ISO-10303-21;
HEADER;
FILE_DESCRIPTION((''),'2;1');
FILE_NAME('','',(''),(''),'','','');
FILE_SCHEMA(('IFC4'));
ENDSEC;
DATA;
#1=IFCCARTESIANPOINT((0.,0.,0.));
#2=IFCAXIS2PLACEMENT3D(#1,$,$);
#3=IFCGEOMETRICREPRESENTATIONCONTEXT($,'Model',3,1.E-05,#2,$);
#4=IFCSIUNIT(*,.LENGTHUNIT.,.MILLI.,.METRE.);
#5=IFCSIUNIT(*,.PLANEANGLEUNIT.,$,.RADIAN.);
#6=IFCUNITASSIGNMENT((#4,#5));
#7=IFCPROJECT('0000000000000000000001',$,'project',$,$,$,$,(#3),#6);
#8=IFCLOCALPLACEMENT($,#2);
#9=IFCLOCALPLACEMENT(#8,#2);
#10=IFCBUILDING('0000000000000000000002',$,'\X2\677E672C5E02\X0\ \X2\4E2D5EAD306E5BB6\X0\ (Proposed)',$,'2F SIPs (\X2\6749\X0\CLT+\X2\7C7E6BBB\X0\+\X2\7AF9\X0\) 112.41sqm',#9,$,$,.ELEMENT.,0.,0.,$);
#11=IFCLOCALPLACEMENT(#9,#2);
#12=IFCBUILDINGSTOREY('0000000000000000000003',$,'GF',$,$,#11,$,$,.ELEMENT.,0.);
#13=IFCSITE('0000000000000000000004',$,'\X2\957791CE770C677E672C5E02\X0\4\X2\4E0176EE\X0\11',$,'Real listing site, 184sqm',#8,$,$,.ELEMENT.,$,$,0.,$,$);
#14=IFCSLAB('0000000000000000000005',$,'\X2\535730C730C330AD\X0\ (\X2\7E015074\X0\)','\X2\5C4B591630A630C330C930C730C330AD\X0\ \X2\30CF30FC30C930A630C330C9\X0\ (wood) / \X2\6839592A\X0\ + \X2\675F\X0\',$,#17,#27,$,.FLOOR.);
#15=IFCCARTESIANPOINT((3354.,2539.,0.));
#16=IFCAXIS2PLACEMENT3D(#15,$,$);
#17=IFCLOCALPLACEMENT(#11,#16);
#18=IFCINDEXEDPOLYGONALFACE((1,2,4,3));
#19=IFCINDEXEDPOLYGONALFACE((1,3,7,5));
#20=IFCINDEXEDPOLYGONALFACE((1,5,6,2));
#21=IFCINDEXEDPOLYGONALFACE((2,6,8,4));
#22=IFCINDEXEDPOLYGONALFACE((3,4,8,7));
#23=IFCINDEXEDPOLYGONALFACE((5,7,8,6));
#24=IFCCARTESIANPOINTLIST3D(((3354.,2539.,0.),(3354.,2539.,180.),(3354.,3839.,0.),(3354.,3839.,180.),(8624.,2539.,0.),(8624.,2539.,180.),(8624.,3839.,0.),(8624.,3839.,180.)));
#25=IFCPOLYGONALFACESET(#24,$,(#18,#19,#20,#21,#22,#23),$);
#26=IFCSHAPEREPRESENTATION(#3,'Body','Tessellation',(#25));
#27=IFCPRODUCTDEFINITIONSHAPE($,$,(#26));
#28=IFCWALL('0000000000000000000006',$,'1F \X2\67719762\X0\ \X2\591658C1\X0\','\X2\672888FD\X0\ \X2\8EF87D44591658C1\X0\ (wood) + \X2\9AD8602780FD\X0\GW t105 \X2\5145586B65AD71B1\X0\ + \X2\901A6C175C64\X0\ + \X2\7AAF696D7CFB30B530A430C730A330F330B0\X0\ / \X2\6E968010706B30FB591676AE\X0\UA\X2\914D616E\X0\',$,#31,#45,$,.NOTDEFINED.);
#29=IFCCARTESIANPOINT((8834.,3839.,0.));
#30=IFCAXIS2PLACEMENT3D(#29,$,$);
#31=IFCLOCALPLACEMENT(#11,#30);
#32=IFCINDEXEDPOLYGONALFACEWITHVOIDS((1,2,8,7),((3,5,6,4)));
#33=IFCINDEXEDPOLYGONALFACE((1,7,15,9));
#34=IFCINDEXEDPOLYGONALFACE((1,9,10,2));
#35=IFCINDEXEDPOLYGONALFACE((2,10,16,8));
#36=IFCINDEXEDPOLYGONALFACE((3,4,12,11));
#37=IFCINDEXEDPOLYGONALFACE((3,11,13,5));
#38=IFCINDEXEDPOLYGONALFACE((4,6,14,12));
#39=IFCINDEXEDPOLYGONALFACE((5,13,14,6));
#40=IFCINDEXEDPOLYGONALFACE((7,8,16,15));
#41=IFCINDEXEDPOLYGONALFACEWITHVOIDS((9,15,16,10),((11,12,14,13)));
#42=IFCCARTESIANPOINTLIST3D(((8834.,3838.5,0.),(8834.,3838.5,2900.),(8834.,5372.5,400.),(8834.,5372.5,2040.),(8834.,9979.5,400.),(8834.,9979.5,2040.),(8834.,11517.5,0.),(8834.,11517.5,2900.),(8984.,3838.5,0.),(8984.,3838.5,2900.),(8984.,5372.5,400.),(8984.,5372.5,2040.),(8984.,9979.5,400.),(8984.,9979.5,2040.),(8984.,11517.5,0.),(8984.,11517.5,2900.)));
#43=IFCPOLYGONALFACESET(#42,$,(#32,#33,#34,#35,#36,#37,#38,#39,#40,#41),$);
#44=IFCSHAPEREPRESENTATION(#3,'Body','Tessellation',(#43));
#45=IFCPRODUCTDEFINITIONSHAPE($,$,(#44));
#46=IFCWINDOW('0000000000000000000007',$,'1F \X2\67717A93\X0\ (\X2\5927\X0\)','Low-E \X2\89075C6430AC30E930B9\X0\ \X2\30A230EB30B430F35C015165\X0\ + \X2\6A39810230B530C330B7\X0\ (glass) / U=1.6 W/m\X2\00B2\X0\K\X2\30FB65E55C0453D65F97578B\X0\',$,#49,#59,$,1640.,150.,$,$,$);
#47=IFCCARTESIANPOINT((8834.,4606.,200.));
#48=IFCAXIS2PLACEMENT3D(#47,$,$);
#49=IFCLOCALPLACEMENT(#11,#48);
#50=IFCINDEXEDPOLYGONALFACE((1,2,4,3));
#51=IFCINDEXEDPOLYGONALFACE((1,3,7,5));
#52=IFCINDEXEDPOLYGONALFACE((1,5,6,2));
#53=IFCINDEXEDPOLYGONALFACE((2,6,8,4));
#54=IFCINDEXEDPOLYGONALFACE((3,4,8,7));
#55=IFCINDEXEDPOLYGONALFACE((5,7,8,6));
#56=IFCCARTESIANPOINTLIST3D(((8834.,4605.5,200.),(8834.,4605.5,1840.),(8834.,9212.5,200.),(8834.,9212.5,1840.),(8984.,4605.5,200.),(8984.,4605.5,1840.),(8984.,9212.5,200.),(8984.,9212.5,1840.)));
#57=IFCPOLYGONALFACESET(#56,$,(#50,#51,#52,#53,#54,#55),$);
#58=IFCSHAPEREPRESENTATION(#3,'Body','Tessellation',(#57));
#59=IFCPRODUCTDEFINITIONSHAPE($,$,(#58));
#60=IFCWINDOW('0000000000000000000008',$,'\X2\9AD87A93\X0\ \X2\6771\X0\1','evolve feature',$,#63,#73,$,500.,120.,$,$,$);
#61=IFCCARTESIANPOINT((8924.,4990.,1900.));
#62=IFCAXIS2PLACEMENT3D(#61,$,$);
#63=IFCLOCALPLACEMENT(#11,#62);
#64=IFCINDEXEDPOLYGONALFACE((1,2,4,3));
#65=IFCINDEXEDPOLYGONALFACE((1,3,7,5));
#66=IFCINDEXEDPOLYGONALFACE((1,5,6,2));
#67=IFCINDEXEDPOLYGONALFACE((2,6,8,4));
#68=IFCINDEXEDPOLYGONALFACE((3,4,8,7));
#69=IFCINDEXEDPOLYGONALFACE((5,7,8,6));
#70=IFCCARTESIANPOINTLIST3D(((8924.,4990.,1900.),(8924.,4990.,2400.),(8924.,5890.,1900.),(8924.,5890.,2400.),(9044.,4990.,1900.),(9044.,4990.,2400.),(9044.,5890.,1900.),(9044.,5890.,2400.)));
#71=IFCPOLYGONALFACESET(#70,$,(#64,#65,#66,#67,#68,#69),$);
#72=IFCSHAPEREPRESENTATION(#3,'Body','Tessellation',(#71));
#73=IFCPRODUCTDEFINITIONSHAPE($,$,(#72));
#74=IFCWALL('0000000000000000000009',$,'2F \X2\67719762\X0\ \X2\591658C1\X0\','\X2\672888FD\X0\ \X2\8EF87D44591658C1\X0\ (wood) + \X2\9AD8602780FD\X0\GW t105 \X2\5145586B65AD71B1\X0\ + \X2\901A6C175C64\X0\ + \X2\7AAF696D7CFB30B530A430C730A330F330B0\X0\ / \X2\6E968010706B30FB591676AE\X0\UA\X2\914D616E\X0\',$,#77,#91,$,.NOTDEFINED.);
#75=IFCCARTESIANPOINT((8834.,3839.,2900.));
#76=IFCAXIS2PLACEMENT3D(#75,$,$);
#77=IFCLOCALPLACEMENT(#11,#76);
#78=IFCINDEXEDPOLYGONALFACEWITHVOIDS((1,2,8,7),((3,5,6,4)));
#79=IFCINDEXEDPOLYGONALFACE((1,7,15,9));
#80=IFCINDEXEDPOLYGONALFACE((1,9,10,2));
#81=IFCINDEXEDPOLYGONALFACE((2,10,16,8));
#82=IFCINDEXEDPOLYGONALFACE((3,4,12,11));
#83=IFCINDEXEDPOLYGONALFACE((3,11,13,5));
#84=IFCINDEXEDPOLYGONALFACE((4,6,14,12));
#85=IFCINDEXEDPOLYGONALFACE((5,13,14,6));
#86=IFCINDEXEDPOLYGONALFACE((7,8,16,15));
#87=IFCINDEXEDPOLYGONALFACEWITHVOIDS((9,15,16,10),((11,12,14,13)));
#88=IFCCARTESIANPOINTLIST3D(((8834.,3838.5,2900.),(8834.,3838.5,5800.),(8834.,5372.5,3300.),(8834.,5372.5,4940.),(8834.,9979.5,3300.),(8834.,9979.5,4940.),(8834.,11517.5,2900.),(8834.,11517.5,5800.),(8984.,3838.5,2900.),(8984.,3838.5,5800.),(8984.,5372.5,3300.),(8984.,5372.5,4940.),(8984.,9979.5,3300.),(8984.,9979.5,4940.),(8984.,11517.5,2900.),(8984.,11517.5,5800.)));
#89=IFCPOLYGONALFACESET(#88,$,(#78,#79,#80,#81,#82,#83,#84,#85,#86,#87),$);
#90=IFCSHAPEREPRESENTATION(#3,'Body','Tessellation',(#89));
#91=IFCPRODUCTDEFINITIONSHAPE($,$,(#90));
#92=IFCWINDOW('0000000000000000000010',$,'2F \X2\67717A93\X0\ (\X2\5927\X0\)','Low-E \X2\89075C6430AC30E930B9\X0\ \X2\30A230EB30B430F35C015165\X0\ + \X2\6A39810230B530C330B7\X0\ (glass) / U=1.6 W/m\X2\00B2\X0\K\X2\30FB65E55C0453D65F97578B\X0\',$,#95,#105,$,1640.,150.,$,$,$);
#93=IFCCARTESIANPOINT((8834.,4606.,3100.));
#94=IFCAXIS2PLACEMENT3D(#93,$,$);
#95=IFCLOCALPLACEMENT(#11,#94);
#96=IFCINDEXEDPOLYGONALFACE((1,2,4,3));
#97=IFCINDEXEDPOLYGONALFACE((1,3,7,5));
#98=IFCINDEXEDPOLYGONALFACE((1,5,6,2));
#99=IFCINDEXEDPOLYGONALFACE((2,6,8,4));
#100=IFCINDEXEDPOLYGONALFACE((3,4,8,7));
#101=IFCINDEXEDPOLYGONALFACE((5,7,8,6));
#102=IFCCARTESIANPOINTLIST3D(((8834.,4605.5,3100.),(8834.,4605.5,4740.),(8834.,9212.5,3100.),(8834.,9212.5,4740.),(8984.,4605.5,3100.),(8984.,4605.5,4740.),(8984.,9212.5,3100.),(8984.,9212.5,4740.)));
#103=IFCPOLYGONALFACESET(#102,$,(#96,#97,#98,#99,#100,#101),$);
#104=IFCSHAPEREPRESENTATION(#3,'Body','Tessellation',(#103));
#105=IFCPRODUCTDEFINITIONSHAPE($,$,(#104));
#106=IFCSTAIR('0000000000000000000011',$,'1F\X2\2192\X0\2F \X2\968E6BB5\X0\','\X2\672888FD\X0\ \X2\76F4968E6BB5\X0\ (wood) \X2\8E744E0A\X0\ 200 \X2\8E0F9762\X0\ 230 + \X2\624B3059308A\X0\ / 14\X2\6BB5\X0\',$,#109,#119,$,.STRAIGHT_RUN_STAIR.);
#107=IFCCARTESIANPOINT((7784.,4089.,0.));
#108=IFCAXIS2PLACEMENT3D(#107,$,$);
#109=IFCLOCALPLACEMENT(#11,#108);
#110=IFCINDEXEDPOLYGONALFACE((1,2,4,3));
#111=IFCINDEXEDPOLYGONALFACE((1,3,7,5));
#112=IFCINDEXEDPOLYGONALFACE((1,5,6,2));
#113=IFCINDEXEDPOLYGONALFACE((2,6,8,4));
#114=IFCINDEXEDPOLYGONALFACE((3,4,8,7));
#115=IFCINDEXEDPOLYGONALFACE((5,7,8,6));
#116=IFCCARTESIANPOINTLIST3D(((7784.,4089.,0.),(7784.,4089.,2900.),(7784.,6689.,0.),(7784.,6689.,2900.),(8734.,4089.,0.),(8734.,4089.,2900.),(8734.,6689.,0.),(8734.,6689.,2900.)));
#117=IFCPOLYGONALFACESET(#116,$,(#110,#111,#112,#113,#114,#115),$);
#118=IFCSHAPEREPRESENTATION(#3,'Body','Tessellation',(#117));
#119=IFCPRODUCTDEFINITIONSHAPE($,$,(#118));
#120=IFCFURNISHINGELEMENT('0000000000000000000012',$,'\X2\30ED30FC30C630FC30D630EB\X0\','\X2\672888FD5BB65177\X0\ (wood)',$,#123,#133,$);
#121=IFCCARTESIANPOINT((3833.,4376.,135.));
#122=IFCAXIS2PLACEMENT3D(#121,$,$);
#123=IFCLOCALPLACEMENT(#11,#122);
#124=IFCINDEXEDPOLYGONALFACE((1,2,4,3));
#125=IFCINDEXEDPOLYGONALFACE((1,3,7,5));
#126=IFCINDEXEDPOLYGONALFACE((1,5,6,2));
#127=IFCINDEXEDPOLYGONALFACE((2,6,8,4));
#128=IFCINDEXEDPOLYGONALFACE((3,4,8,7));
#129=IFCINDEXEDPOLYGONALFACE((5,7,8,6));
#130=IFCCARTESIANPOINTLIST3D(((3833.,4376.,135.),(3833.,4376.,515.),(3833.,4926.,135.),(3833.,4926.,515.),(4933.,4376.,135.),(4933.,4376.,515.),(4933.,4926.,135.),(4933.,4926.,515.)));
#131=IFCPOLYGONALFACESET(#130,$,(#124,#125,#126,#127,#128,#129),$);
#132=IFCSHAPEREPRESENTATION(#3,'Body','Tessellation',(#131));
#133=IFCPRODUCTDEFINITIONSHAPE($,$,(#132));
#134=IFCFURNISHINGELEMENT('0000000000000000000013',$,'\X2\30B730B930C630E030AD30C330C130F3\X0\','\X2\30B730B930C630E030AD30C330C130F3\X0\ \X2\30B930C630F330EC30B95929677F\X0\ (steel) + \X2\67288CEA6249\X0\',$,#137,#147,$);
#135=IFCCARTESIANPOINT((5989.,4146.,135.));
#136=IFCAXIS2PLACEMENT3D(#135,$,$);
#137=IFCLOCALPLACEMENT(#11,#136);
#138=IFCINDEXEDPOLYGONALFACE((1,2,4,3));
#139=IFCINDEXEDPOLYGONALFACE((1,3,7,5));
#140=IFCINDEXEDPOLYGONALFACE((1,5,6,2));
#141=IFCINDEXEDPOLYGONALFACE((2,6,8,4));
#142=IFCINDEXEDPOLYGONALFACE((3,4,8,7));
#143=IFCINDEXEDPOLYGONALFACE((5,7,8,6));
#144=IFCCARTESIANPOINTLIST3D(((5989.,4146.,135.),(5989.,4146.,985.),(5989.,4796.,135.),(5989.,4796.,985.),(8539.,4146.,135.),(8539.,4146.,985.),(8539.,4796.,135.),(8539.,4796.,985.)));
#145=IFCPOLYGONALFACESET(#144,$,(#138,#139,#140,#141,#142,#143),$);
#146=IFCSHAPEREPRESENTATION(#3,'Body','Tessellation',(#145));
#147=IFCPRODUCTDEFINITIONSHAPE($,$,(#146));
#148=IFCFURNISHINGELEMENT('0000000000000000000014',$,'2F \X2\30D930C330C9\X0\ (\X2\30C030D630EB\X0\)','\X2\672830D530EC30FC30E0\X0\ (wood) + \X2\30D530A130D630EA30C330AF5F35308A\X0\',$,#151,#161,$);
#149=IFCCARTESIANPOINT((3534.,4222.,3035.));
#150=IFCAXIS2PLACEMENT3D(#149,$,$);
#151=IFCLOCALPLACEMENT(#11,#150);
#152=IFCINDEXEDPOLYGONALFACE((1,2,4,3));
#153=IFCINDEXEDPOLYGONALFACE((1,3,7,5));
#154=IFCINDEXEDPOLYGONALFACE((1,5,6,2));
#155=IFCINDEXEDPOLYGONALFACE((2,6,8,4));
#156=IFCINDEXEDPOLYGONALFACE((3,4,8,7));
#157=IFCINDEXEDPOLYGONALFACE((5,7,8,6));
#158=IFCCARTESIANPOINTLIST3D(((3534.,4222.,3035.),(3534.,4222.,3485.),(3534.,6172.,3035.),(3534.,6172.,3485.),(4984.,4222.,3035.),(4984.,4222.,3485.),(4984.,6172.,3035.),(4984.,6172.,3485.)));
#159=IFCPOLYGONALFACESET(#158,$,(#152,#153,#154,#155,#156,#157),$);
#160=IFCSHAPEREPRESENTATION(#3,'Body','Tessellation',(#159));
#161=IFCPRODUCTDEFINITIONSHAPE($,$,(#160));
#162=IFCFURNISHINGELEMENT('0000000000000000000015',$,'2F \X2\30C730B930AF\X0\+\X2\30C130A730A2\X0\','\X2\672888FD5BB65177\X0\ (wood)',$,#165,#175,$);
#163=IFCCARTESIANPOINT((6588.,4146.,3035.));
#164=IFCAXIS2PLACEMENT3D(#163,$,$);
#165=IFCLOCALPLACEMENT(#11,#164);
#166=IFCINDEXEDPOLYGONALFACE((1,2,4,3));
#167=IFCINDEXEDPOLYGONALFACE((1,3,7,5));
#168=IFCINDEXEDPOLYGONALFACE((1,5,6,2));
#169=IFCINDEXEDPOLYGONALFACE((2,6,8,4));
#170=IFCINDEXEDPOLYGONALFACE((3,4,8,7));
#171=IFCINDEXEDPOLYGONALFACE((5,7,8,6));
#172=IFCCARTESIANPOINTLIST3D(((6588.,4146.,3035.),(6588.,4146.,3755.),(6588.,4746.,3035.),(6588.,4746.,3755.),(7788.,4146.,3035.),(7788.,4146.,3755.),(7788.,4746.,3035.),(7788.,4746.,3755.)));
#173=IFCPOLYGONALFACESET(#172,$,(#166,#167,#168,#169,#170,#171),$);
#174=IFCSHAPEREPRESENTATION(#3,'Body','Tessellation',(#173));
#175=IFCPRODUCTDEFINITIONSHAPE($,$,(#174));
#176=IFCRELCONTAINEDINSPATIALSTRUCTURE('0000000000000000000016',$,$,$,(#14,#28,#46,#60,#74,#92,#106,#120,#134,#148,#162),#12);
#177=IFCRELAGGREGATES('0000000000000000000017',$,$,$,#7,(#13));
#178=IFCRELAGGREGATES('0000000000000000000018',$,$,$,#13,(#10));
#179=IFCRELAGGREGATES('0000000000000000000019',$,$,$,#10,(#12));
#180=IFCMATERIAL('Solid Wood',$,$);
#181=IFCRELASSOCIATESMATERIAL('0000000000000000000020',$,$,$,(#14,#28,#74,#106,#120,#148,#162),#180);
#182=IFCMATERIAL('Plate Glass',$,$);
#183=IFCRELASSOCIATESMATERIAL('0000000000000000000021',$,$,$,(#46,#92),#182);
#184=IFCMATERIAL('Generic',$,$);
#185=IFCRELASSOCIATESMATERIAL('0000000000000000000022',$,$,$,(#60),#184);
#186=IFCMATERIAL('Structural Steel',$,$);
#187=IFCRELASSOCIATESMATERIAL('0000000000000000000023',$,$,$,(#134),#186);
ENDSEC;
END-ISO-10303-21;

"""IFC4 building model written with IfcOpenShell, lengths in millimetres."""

from ifc_helpers import new_model, si_unit, frame, frame_2d, origin, place, context, project, spatial, rectangle, extrude, material, element, fill, save


model = new_model("IFC4")

# Units and contexts
model_context = context("Model", 3, precision=1e-05, world=origin())
ifc_project = project(units=[si_unit("LENGTHUNIT", "METRE", prefix="MILLI"), si_unit("PLANEANGLEUNIT", "RADIAN")], contexts=[model_context])

# Site, building, storey
site_placement = place(None, origin())
site = spatial("IfcSite", under=ifc_project, at=site_placement, Name="長野県松本市4丁目11", ObjectType="Real listing site, 184sqm", CompositionType="ELEMENT", RefElevation=0.0)
building_placement = place(site_placement, origin())
building = spatial("IfcBuilding", under=site, at=building_placement, Name="松本市 中庭の家 (Proposed)", ObjectType="2F SIPs (杉CLT+籾殻+竹) 112.41sqm", CompositionType="ELEMENT", ElevationOfRefHeight=0.0, ElevationOfTerrain=0.0)
storey_placement = place(building_placement, origin())
storey = spatial("IfcBuildingStorey", under=building, at=storey_placement, Name="GF", CompositionType="ELEMENT", Elevation=0.0)

# Slab
ifc_material_1 = material(Name="Solid Wood")
slab_placement = place(storey_placement, frame((3354.0, 2539.0, 0.0)))
element("IfcSlab", 1, at=slab_placement, inside=storey, material=ifc_material_1, Name="南デッキ (縁側)", Description="屋外ウッドデッキ ハードウッド (wood) / 根太 + 束", PredefinedType="FLOOR", context=model_context, shape_type="SweptSolid", body=[
    extrude(rectangle(XDim=5270.0, YDim=1300.0, at=frame_2d((2635.0, 650.0))), frame((3354.0, 2539.0, 0.0)), (0.0, 0.0, 1.0), 180.0),
])

# Wall, openings, windows
wall_1_placement = place(storey_placement, frame((8834.0, 3839.0, 0.0)))
wall_1 = element("IfcWall", 2, at=wall_1_placement, inside=storey, material=ifc_material_1, Name="1F 東面 外壁", Description="木製 軸組外壁 (wood) + 高性能GW t105 充填断熱 + 通気層 + 窯業系サイディング / 準耐火・外皮UA配慮", PredefinedType="NOTDEFINED", context=model_context, shape_type="SweptSolid", body=[
    extrude(rectangle(XDim=150.0, YDim=7679.0, at=frame_2d((75.0, 3839.0))), frame((8834.0, 3839.0, 0.0)), (0.0, 0.0, 1.0), 2900.0),
])
opening_1_placement = place(storey_placement, frame((8834.0, 4606.0, 200.0)))
opening_1 = element("IfcOpeningElement", 3, at=opening_1_placement, cuts=wall_1, PredefinedType="NOTDEFINED", context=model_context, shape_type="SweptSolid", body=[
    extrude(rectangle(XDim=150.0, YDim=4607.0, at=frame_2d((75.0, 2303.0))), frame((8834.0, 4606.0, 200.0)), (0.0, 0.0, 1.0), 1640.0),
])
opening_2_placement = place(storey_placement, frame((8924.0, 4990.0, 1900.0)))
opening_2 = element("IfcOpeningElement", 4, at=opening_2_placement, cuts=wall_1, PredefinedType="NOTDEFINED", context=model_context, shape_type="SweptSolid", body=[
    extrude(rectangle(XDim=120.0, YDim=900.0, at=frame_2d((60.0, 450.0))), frame((8924.0, 4990.0, 1900.0)), (0.0, 0.0, 1.0), 500.0),
])
ifc_material_2 = material(Name="Plate Glass")
window_1_placement = place(storey_placement, frame((8834.0, 4606.0, 200.0)))
window_1 = element("IfcWindow", 5, at=window_1_placement, inside=storey, material=ifc_material_2, Name="1F 東窓 (大)", Description="Low-E 複層ガラス アルゴン封入 + 樹脂サッシ (glass) / U=1.6 W/m²K・日射取得型", OverallHeight=1640.0, OverallWidth=150.0, context=model_context, shape_type="SweptSolid", body=[
    extrude(rectangle(XDim=150.0, YDim=4607.0, at=frame_2d((75.0, 2303.0))), frame((8834.0, 4606.0, 200.0)), (0.0, 0.0, 1.0), 1640.0),
])
fill(opening_1, window_1)
ifc_material_3 = material(Name="Generic")
window_2_placement = place(storey_placement, frame((8924.0, 4990.0, 1900.0)))
window_2 = element("IfcWindow", 6, at=window_2_placement, inside=storey, material=ifc_material_3, Name="高窓 東1", Description="evolve feature", OverallHeight=500.0, OverallWidth=120.0, context=model_context, shape_type="SweptSolid", body=[
    extrude(rectangle(XDim=120.0, YDim=900.0, at=frame_2d((60.0, 450.0))), frame((8924.0, 4990.0, 1900.0)), (0.0, 0.0, 1.0), 500.0),
])
fill(opening_2, window_2)

# Wall, opening, window
wall_2_placement = place(storey_placement, frame((8834.0, 3839.0, 2900.0)))
wall_2 = element("IfcWall", 7, at=wall_2_placement, inside=storey, material=ifc_material_1, Name="2F 東面 外壁", Description="木製 軸組外壁 (wood) + 高性能GW t105 充填断熱 + 通気層 + 窯業系サイディング / 準耐火・外皮UA配慮", PredefinedType="NOTDEFINED", context=model_context, shape_type="SweptSolid", body=[
    extrude(rectangle(XDim=150.0, YDim=7679.0, at=frame_2d((75.0, 3839.0))), frame((8834.0, 3839.0, 2900.0)), (0.0, 0.0, 1.0), 2900.0),
])
opening_3_placement = place(storey_placement, frame((8834.0, 4606.0, 3100.0)))
opening_3 = element("IfcOpeningElement", 8, at=opening_3_placement, cuts=wall_2, PredefinedType="NOTDEFINED", context=model_context, shape_type="SweptSolid", body=[
    extrude(rectangle(XDim=150.0, YDim=4607.0, at=frame_2d((75.0, 2303.0))), frame((8834.0, 4606.0, 3100.0)), (0.0, 0.0, 1.0), 1640.0),
])
window_3_placement = place(storey_placement, frame((8834.0, 4606.0, 3100.0)))
window_3 = element("IfcWindow", 9, at=window_3_placement, inside=storey, material=ifc_material_2, Name="2F 東窓 (大)", Description="Low-E 複層ガラス アルゴン封入 + 樹脂サッシ (glass) / U=1.6 W/m²K・日射取得型", OverallHeight=1640.0, OverallWidth=150.0, context=model_context, shape_type="SweptSolid", body=[
    extrude(rectangle(XDim=150.0, YDim=4607.0, at=frame_2d((75.0, 2303.0))), frame((8834.0, 4606.0, 3100.0)), (0.0, 0.0, 1.0), 1640.0),
])
fill(opening_3, window_3)

# Stair
stair_placement = place(storey_placement, frame((7784.0, 4089.0, 0.0)))
element("IfcStair", 10, at=stair_placement, inside=storey, material=ifc_material_1, Name="1F→2F 階段", Description="木製 直階段 (wood) 蹴上 200 踏面 230 + 手すり / 14段", PredefinedType="STRAIGHT_RUN_STAIR", context=model_context, shape_type="SweptSolid", body=[
    extrude(rectangle(XDim=950.0, YDim=2600.0, at=frame_2d((475.0, 1300.0))), frame((7784.0, 4089.0, 0.0)), (0.0, 0.0, 1.0), 2900.0),
])

# Furnishing elements
furnishing_1_placement = place(storey_placement, frame((3833.0, 4376.0, 135.0)))
element("IfcFurnishingElement", 11, at=furnishing_1_placement, inside=storey, material=ifc_material_1, Name="ローテーブル", Description="木製家具 (wood)", context=model_context, shape_type="SweptSolid", body=[
    extrude(rectangle(XDim=1100.0, YDim=550.0, at=frame_2d((550.0, 275.0))), frame((3833.0, 4376.0, 135.0)), (0.0, 0.0, 1.0), 380.0),
])
ifc_material_4 = material(Name="Structural Steel")
furnishing_2_placement = place(storey_placement, frame((5989.0, 4146.0, 135.0)))
element("IfcFurnishingElement", 12, at=furnishing_2_placement, inside=storey, material=ifc_material_4, Name="システムキッチン", Description="システムキッチン ステンレス天板 (steel) + 木質扉", context=model_context, shape_type="SweptSolid", body=[
    extrude(rectangle(XDim=2550.0, YDim=650.0, at=frame_2d((1275.0, 325.0))), frame((5989.0, 4146.0, 135.0)), (0.0, 0.0, 1.0), 850.0),
])
furnishing_3_placement = place(storey_placement, frame((3534.0, 4222.0, 3035.0)))
element("IfcFurnishingElement", 13, at=furnishing_3_placement, inside=storey, material=ifc_material_1, Name="2F ベッド (ダブル)", Description="木フレーム (wood) + ファブリック張り", context=model_context, shape_type="SweptSolid", body=[
    extrude(rectangle(XDim=1450.0, YDim=1950.0, at=frame_2d((725.0, 975.0))), frame((3534.0, 4222.0, 3035.0)), (0.0, 0.0, 1.0), 450.0),
])
furnishing_4_placement = place(storey_placement, frame((6588.0, 4146.0, 3035.0)))
element("IfcFurnishingElement", 14, at=furnishing_4_placement, inside=storey, material=ifc_material_1, Name="2F デスク+チェア", Description="木製家具 (wood)", context=model_context, shape_type="SweptSolid", body=[
    extrude(rectangle(XDim=1200.0, YDim=600.0, at=frame_2d((600.0, 300.0))), frame((6588.0, 4146.0, 3035.0)), (0.0, 0.0, 1.0), 720.0),
])

save(model, "model.ifc")
